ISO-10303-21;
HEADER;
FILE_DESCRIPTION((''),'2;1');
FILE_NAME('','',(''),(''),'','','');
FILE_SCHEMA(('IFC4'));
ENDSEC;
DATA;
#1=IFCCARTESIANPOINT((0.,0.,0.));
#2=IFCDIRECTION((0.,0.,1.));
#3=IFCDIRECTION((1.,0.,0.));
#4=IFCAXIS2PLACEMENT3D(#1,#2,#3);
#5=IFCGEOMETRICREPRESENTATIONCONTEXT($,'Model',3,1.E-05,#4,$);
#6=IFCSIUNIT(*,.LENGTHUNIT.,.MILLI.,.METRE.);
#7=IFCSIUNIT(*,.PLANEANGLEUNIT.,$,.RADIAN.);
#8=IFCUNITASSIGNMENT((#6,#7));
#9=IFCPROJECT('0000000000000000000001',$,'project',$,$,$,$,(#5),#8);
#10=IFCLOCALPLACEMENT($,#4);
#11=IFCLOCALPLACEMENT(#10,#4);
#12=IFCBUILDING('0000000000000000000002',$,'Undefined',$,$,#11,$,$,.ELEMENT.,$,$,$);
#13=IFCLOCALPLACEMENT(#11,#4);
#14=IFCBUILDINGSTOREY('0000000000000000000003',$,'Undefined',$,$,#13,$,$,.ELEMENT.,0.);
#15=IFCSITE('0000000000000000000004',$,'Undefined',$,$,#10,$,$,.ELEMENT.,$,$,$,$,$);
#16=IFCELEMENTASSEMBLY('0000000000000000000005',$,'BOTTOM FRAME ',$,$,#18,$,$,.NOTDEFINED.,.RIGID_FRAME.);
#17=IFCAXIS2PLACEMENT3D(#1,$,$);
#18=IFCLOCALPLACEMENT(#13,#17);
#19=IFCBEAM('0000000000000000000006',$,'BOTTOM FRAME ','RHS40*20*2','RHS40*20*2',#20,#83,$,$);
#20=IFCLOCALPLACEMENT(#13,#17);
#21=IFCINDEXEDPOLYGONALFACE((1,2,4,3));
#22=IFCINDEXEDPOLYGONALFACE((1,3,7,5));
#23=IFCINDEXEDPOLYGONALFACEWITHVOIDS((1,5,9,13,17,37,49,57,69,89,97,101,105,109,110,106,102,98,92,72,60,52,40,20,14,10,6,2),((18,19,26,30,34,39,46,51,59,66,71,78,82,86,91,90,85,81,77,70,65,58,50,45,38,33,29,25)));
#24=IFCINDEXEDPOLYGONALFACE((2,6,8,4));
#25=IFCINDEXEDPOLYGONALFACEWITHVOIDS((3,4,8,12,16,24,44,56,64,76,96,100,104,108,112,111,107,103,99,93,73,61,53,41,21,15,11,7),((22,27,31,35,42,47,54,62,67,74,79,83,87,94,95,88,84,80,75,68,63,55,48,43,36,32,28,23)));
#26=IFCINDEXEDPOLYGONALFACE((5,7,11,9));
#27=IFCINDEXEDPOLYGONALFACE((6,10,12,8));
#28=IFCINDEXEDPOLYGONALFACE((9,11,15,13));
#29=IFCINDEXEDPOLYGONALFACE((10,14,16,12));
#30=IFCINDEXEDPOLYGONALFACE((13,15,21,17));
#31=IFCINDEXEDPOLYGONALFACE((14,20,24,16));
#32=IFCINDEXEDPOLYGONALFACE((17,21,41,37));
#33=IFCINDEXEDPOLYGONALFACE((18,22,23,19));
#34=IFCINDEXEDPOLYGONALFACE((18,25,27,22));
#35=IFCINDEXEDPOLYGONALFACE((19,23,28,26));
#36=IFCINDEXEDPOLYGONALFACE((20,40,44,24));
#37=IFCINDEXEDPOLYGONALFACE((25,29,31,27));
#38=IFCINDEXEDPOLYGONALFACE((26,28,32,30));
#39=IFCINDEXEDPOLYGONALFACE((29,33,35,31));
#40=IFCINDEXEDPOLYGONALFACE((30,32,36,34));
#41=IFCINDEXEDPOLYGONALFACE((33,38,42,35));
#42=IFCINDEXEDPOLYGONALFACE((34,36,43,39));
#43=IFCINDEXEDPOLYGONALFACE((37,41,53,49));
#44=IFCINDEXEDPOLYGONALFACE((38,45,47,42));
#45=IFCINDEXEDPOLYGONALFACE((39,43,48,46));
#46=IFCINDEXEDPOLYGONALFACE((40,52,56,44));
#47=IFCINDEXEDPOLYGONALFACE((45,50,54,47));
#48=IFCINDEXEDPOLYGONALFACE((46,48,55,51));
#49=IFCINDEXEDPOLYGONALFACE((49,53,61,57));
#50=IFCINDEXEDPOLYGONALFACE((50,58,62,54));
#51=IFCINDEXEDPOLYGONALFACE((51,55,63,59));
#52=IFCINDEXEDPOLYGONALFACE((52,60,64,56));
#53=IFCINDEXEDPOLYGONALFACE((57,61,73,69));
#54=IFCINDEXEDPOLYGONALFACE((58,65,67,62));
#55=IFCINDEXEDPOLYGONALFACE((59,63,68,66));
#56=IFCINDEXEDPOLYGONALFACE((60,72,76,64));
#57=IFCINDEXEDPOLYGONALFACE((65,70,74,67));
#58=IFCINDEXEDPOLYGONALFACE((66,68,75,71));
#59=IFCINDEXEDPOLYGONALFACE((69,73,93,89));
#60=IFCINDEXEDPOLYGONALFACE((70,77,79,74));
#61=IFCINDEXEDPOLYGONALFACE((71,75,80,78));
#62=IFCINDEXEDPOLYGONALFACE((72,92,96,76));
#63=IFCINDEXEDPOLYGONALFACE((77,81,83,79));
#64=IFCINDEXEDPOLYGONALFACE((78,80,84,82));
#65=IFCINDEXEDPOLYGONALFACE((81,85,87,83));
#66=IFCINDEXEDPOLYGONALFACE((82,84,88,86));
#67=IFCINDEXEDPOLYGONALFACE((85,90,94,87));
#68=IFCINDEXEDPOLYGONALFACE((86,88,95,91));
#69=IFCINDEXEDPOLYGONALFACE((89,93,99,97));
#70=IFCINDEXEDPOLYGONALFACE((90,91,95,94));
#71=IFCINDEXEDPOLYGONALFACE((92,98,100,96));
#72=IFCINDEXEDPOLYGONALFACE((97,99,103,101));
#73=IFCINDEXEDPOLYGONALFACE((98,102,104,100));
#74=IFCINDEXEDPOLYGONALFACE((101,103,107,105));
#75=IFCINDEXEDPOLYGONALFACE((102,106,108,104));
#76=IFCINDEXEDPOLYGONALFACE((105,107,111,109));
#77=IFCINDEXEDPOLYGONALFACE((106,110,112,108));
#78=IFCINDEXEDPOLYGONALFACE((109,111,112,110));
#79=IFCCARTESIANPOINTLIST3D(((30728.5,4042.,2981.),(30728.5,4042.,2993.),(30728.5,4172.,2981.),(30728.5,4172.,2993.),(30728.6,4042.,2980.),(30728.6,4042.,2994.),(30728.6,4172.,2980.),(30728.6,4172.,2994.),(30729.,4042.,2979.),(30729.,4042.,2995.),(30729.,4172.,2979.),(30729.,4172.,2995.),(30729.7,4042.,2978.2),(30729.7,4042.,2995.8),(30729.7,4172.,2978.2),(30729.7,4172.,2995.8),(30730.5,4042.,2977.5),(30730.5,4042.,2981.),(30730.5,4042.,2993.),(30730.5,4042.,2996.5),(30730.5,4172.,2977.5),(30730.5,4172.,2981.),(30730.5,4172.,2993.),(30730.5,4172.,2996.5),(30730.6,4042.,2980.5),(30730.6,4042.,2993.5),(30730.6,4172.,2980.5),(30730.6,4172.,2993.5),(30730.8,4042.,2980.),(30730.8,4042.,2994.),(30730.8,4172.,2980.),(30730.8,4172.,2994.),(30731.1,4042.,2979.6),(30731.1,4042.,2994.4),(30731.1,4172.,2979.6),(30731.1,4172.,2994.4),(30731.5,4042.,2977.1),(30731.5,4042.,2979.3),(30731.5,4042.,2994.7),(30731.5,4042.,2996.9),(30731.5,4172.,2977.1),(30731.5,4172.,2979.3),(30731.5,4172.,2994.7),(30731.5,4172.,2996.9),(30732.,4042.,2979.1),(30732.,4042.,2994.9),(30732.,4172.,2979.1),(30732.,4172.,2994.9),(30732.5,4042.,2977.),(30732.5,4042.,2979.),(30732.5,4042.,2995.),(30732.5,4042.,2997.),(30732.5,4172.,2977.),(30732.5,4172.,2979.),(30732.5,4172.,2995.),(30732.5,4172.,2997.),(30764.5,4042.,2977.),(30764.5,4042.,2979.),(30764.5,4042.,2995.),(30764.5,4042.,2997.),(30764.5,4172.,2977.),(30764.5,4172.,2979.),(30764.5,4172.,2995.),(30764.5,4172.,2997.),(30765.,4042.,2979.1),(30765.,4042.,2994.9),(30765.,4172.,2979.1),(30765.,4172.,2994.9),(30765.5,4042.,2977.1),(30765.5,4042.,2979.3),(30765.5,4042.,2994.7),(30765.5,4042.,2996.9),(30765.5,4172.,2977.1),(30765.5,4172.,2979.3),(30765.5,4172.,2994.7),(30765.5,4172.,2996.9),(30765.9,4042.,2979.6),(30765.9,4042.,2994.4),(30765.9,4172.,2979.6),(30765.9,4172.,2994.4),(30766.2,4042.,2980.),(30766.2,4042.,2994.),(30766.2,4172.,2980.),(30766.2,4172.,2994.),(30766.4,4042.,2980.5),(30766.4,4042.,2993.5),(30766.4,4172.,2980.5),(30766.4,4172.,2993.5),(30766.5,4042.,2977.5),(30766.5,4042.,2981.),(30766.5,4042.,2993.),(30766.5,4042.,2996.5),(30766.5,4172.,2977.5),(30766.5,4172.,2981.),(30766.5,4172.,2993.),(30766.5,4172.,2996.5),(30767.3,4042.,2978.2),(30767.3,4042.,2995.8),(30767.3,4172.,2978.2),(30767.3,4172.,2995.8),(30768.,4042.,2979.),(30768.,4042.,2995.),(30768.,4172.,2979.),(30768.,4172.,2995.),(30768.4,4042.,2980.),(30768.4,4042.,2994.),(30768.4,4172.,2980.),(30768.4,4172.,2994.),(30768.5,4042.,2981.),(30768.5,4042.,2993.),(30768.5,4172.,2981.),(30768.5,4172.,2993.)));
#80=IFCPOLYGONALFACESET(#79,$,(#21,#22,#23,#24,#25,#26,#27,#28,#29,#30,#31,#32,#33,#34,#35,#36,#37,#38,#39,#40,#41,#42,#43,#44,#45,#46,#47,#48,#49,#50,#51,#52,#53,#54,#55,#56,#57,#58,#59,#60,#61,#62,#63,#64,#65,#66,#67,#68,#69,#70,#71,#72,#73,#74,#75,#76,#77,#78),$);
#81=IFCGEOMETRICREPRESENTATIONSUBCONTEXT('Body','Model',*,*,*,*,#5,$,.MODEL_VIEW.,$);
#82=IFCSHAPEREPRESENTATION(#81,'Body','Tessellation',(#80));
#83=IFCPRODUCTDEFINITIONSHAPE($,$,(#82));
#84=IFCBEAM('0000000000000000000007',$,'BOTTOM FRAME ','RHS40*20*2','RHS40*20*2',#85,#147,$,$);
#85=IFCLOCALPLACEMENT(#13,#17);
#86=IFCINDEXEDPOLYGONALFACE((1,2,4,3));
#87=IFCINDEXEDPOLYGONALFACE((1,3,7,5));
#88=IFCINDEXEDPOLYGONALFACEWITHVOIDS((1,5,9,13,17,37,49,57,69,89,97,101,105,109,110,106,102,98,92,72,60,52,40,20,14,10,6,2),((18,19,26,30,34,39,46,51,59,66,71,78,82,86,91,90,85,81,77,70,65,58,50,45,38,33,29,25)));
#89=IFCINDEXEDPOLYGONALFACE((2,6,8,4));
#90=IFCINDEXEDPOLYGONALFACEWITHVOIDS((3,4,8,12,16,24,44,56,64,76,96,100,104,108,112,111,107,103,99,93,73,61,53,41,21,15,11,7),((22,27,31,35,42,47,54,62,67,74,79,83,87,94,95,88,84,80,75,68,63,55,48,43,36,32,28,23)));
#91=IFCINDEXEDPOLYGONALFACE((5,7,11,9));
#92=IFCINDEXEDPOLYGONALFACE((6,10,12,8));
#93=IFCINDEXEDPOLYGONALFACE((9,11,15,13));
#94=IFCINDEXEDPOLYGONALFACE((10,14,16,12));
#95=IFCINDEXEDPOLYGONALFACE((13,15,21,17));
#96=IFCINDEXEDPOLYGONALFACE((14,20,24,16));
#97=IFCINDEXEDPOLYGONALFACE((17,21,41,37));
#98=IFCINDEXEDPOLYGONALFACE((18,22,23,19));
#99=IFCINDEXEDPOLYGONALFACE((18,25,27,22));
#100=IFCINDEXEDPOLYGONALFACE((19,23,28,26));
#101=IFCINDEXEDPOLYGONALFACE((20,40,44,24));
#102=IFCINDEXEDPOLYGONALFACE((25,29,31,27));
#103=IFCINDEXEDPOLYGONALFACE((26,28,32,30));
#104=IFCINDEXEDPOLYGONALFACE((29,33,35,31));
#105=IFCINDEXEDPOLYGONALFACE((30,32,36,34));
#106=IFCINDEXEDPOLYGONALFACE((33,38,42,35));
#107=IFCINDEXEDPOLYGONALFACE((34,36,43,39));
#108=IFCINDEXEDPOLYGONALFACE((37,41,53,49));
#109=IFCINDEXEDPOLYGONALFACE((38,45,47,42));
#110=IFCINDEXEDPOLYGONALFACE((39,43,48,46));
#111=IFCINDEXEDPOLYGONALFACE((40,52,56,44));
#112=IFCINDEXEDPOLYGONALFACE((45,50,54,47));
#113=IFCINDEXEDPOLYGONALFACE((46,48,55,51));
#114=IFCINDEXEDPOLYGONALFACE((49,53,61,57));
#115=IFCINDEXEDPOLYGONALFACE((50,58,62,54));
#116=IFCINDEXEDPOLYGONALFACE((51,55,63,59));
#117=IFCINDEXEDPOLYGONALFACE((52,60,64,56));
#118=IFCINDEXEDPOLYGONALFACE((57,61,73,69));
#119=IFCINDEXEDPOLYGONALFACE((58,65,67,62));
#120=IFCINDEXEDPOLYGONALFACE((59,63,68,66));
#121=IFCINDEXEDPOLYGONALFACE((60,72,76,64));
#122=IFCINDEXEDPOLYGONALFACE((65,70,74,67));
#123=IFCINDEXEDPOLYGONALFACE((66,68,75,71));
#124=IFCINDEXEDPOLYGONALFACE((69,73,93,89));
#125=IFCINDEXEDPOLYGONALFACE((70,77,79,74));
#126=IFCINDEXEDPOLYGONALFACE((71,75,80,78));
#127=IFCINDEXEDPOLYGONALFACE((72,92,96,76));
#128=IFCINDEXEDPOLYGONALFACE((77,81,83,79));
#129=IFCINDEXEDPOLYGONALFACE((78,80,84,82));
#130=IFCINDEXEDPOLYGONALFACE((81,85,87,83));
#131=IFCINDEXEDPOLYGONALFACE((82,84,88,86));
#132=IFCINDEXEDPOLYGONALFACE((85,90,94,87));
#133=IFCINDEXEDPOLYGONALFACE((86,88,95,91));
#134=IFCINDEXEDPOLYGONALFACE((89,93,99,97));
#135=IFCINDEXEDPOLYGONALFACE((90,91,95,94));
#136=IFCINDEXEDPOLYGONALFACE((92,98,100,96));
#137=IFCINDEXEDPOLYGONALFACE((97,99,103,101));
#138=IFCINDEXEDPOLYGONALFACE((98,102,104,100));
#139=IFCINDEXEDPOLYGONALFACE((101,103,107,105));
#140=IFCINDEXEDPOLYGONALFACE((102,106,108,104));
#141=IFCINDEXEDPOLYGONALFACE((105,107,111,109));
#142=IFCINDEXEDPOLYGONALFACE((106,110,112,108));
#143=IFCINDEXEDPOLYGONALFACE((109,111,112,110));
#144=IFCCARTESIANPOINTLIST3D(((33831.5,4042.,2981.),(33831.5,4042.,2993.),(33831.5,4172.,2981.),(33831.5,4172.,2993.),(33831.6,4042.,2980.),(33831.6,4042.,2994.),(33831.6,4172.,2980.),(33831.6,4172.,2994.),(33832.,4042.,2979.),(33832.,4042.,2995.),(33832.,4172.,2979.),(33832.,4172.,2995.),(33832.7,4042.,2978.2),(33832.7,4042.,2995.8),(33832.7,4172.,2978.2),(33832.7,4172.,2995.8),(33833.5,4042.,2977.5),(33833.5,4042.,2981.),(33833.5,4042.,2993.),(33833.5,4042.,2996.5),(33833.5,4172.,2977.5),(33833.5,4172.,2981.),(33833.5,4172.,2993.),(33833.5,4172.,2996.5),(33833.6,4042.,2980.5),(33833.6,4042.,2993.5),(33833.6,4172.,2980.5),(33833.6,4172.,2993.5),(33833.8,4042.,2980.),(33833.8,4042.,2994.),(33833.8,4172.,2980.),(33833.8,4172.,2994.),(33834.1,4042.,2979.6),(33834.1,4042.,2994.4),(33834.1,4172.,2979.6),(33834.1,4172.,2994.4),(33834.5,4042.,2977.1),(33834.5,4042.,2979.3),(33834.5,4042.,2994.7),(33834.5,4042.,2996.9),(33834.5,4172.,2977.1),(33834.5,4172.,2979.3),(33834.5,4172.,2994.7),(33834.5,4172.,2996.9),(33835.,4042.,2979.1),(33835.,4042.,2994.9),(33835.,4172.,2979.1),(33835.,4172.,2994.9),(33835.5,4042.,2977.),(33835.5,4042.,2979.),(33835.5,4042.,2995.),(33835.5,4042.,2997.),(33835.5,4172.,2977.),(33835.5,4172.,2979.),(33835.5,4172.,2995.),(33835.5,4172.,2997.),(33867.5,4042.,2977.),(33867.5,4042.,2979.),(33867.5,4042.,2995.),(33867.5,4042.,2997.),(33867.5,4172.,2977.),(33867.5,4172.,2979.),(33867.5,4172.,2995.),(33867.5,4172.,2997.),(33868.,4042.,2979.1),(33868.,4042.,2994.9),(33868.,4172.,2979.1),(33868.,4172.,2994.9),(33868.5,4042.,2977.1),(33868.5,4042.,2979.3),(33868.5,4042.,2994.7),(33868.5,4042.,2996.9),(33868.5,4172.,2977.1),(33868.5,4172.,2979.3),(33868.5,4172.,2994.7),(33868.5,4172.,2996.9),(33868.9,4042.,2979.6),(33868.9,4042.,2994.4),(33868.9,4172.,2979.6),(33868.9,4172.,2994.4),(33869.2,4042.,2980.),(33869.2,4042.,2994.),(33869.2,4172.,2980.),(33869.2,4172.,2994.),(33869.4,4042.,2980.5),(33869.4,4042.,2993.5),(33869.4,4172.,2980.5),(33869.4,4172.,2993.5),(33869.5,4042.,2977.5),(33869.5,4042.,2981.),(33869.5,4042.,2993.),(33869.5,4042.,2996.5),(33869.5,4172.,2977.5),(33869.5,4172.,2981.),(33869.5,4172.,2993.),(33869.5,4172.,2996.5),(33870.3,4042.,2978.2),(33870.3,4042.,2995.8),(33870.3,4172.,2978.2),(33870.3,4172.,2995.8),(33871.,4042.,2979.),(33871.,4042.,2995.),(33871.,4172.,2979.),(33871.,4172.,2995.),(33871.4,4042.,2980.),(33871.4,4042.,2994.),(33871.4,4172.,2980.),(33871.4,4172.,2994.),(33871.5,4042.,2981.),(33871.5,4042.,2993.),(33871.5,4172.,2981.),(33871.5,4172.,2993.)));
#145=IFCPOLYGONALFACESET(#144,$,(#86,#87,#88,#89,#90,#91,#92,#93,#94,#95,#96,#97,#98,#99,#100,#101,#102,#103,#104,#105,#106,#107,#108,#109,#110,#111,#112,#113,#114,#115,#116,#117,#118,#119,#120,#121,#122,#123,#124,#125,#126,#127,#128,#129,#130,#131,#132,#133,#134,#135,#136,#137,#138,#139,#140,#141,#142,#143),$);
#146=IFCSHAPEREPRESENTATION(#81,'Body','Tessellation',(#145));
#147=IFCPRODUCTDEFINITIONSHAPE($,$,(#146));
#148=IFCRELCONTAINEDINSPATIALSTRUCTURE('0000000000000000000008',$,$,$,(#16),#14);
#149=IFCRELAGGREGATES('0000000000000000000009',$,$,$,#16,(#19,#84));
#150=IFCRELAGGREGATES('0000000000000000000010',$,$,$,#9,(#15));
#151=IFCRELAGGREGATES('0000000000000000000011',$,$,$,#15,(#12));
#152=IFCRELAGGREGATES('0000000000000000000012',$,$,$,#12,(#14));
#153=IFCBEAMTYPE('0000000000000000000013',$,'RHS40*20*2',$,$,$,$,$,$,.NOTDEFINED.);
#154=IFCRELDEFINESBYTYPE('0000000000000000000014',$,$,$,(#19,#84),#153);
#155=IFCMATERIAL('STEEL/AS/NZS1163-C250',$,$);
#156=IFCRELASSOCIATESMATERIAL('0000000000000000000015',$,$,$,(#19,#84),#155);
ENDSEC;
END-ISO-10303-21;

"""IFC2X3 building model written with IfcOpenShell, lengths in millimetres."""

from ifc_helpers import new_model, si_unit, frame, origin_with_axes, origin_2d_with_axis, place, context, subcontext, project, spatial, hollow_rectangle, extrude, material, type_object, element, aggregate, save


model = new_model("IFC2X3")

# Units and contexts
model_context = context("Model", 3, precision=1e-05, world=origin_with_axes())
body_context = subcontext(model_context, "Body", "Model", "MODEL_VIEW")
ifc_project = project(units=[si_unit("LENGTHUNIT", "METRE", prefix="MILLI"), si_unit("PLANEANGLEUNIT", "RADIAN")], contexts=[model_context])

# Site, building, storey
site_placement = place(None, origin_with_axes())
site = spatial("IfcSite", under=ifc_project, at=site_placement, Name="Undefined", CompositionType="ELEMENT")
building_placement = place(site_placement, origin_with_axes())
building = spatial("IfcBuilding", under=site, at=building_placement, Name="Undefined", CompositionType="ELEMENT")
storey_placement = place(building_placement, origin_with_axes())
storey = spatial("IfcBuildingStorey", under=building, at=storey_placement, Name="Undefined", CompositionType="ELEMENT", Elevation=0.0)

# Element assembly, beams
assembly_1_placement = place(storey_placement, origin_with_axes())
assembly_1 = element("IfcElementAssembly", 1, at=assembly_1_placement, inside=storey, Name="BOTTOM FRAME ", AssemblyPlace="NOTDEFINED", PredefinedType="RIGID_FRAME")
ifc_material_1 = material(Name="STEEL/AS/NZS1163-C250")
beam_type_1 = type_object("IfcBeamType", Name="RHS40*20*2", PredefinedType="NOTDEFINED")
beam_1_placement = place(assembly_1_placement, frame((30748.5, 4172.0, 2987.0), z_axis=(1.0, 0.0, 0.0), x_axis=(0.0, -1.0, 0.0)))
beam_1 = element("IfcBeam", 2, at=beam_1_placement, type_object=beam_type_1, material=ifc_material_1, Name="BOTTOM FRAME ", Description="RHS40*20*2", ObjectType="RHS40*20*2", context=body_context, shape_type="SweptSolid", body=[
    extrude(hollow_rectangle(XDim=20.0, YDim=40.0, WallThickness=2.0, InnerFilletRadius=2.0, OuterFilletRadius=4.0, at=origin_2d_with_axis()), frame((130.0, 0.0, 0.0), z_axis=(-1.0, 0.0, 0.0), x_axis=(0.0, -1.0, 0.0)), (0.0, 0.0, 1.0), 130.0),
])
beam_2_placement = place(assembly_1_placement, frame((33851.5, 4172.0, 2987.0), z_axis=(-1.0, 0.0, 0.0), x_axis=(0.0, -1.0, 0.0)))
beam_2 = element("IfcBeam", 3, at=beam_2_placement, type_object=beam_type_1, material=ifc_material_1, Name="BOTTOM FRAME ", Description="RHS40*20*2", ObjectType="RHS40*20*2", context=body_context, shape_type="SweptSolid", body=[
    extrude(hollow_rectangle(XDim=20.0, YDim=40.0, WallThickness=2.0, InnerFilletRadius=2.0, OuterFilletRadius=4.0, at=origin_2d_with_axis()), frame((130.0, 0.0, 0.0), z_axis=(-1.0, 0.0, 0.0), x_axis=(0.0, -1.0, 0.0)), (0.0, 0.0, 1.0), 130.0),
])
aggregate(assembly_1, [beam_1, beam_2])

save(model, "model.ifc")
